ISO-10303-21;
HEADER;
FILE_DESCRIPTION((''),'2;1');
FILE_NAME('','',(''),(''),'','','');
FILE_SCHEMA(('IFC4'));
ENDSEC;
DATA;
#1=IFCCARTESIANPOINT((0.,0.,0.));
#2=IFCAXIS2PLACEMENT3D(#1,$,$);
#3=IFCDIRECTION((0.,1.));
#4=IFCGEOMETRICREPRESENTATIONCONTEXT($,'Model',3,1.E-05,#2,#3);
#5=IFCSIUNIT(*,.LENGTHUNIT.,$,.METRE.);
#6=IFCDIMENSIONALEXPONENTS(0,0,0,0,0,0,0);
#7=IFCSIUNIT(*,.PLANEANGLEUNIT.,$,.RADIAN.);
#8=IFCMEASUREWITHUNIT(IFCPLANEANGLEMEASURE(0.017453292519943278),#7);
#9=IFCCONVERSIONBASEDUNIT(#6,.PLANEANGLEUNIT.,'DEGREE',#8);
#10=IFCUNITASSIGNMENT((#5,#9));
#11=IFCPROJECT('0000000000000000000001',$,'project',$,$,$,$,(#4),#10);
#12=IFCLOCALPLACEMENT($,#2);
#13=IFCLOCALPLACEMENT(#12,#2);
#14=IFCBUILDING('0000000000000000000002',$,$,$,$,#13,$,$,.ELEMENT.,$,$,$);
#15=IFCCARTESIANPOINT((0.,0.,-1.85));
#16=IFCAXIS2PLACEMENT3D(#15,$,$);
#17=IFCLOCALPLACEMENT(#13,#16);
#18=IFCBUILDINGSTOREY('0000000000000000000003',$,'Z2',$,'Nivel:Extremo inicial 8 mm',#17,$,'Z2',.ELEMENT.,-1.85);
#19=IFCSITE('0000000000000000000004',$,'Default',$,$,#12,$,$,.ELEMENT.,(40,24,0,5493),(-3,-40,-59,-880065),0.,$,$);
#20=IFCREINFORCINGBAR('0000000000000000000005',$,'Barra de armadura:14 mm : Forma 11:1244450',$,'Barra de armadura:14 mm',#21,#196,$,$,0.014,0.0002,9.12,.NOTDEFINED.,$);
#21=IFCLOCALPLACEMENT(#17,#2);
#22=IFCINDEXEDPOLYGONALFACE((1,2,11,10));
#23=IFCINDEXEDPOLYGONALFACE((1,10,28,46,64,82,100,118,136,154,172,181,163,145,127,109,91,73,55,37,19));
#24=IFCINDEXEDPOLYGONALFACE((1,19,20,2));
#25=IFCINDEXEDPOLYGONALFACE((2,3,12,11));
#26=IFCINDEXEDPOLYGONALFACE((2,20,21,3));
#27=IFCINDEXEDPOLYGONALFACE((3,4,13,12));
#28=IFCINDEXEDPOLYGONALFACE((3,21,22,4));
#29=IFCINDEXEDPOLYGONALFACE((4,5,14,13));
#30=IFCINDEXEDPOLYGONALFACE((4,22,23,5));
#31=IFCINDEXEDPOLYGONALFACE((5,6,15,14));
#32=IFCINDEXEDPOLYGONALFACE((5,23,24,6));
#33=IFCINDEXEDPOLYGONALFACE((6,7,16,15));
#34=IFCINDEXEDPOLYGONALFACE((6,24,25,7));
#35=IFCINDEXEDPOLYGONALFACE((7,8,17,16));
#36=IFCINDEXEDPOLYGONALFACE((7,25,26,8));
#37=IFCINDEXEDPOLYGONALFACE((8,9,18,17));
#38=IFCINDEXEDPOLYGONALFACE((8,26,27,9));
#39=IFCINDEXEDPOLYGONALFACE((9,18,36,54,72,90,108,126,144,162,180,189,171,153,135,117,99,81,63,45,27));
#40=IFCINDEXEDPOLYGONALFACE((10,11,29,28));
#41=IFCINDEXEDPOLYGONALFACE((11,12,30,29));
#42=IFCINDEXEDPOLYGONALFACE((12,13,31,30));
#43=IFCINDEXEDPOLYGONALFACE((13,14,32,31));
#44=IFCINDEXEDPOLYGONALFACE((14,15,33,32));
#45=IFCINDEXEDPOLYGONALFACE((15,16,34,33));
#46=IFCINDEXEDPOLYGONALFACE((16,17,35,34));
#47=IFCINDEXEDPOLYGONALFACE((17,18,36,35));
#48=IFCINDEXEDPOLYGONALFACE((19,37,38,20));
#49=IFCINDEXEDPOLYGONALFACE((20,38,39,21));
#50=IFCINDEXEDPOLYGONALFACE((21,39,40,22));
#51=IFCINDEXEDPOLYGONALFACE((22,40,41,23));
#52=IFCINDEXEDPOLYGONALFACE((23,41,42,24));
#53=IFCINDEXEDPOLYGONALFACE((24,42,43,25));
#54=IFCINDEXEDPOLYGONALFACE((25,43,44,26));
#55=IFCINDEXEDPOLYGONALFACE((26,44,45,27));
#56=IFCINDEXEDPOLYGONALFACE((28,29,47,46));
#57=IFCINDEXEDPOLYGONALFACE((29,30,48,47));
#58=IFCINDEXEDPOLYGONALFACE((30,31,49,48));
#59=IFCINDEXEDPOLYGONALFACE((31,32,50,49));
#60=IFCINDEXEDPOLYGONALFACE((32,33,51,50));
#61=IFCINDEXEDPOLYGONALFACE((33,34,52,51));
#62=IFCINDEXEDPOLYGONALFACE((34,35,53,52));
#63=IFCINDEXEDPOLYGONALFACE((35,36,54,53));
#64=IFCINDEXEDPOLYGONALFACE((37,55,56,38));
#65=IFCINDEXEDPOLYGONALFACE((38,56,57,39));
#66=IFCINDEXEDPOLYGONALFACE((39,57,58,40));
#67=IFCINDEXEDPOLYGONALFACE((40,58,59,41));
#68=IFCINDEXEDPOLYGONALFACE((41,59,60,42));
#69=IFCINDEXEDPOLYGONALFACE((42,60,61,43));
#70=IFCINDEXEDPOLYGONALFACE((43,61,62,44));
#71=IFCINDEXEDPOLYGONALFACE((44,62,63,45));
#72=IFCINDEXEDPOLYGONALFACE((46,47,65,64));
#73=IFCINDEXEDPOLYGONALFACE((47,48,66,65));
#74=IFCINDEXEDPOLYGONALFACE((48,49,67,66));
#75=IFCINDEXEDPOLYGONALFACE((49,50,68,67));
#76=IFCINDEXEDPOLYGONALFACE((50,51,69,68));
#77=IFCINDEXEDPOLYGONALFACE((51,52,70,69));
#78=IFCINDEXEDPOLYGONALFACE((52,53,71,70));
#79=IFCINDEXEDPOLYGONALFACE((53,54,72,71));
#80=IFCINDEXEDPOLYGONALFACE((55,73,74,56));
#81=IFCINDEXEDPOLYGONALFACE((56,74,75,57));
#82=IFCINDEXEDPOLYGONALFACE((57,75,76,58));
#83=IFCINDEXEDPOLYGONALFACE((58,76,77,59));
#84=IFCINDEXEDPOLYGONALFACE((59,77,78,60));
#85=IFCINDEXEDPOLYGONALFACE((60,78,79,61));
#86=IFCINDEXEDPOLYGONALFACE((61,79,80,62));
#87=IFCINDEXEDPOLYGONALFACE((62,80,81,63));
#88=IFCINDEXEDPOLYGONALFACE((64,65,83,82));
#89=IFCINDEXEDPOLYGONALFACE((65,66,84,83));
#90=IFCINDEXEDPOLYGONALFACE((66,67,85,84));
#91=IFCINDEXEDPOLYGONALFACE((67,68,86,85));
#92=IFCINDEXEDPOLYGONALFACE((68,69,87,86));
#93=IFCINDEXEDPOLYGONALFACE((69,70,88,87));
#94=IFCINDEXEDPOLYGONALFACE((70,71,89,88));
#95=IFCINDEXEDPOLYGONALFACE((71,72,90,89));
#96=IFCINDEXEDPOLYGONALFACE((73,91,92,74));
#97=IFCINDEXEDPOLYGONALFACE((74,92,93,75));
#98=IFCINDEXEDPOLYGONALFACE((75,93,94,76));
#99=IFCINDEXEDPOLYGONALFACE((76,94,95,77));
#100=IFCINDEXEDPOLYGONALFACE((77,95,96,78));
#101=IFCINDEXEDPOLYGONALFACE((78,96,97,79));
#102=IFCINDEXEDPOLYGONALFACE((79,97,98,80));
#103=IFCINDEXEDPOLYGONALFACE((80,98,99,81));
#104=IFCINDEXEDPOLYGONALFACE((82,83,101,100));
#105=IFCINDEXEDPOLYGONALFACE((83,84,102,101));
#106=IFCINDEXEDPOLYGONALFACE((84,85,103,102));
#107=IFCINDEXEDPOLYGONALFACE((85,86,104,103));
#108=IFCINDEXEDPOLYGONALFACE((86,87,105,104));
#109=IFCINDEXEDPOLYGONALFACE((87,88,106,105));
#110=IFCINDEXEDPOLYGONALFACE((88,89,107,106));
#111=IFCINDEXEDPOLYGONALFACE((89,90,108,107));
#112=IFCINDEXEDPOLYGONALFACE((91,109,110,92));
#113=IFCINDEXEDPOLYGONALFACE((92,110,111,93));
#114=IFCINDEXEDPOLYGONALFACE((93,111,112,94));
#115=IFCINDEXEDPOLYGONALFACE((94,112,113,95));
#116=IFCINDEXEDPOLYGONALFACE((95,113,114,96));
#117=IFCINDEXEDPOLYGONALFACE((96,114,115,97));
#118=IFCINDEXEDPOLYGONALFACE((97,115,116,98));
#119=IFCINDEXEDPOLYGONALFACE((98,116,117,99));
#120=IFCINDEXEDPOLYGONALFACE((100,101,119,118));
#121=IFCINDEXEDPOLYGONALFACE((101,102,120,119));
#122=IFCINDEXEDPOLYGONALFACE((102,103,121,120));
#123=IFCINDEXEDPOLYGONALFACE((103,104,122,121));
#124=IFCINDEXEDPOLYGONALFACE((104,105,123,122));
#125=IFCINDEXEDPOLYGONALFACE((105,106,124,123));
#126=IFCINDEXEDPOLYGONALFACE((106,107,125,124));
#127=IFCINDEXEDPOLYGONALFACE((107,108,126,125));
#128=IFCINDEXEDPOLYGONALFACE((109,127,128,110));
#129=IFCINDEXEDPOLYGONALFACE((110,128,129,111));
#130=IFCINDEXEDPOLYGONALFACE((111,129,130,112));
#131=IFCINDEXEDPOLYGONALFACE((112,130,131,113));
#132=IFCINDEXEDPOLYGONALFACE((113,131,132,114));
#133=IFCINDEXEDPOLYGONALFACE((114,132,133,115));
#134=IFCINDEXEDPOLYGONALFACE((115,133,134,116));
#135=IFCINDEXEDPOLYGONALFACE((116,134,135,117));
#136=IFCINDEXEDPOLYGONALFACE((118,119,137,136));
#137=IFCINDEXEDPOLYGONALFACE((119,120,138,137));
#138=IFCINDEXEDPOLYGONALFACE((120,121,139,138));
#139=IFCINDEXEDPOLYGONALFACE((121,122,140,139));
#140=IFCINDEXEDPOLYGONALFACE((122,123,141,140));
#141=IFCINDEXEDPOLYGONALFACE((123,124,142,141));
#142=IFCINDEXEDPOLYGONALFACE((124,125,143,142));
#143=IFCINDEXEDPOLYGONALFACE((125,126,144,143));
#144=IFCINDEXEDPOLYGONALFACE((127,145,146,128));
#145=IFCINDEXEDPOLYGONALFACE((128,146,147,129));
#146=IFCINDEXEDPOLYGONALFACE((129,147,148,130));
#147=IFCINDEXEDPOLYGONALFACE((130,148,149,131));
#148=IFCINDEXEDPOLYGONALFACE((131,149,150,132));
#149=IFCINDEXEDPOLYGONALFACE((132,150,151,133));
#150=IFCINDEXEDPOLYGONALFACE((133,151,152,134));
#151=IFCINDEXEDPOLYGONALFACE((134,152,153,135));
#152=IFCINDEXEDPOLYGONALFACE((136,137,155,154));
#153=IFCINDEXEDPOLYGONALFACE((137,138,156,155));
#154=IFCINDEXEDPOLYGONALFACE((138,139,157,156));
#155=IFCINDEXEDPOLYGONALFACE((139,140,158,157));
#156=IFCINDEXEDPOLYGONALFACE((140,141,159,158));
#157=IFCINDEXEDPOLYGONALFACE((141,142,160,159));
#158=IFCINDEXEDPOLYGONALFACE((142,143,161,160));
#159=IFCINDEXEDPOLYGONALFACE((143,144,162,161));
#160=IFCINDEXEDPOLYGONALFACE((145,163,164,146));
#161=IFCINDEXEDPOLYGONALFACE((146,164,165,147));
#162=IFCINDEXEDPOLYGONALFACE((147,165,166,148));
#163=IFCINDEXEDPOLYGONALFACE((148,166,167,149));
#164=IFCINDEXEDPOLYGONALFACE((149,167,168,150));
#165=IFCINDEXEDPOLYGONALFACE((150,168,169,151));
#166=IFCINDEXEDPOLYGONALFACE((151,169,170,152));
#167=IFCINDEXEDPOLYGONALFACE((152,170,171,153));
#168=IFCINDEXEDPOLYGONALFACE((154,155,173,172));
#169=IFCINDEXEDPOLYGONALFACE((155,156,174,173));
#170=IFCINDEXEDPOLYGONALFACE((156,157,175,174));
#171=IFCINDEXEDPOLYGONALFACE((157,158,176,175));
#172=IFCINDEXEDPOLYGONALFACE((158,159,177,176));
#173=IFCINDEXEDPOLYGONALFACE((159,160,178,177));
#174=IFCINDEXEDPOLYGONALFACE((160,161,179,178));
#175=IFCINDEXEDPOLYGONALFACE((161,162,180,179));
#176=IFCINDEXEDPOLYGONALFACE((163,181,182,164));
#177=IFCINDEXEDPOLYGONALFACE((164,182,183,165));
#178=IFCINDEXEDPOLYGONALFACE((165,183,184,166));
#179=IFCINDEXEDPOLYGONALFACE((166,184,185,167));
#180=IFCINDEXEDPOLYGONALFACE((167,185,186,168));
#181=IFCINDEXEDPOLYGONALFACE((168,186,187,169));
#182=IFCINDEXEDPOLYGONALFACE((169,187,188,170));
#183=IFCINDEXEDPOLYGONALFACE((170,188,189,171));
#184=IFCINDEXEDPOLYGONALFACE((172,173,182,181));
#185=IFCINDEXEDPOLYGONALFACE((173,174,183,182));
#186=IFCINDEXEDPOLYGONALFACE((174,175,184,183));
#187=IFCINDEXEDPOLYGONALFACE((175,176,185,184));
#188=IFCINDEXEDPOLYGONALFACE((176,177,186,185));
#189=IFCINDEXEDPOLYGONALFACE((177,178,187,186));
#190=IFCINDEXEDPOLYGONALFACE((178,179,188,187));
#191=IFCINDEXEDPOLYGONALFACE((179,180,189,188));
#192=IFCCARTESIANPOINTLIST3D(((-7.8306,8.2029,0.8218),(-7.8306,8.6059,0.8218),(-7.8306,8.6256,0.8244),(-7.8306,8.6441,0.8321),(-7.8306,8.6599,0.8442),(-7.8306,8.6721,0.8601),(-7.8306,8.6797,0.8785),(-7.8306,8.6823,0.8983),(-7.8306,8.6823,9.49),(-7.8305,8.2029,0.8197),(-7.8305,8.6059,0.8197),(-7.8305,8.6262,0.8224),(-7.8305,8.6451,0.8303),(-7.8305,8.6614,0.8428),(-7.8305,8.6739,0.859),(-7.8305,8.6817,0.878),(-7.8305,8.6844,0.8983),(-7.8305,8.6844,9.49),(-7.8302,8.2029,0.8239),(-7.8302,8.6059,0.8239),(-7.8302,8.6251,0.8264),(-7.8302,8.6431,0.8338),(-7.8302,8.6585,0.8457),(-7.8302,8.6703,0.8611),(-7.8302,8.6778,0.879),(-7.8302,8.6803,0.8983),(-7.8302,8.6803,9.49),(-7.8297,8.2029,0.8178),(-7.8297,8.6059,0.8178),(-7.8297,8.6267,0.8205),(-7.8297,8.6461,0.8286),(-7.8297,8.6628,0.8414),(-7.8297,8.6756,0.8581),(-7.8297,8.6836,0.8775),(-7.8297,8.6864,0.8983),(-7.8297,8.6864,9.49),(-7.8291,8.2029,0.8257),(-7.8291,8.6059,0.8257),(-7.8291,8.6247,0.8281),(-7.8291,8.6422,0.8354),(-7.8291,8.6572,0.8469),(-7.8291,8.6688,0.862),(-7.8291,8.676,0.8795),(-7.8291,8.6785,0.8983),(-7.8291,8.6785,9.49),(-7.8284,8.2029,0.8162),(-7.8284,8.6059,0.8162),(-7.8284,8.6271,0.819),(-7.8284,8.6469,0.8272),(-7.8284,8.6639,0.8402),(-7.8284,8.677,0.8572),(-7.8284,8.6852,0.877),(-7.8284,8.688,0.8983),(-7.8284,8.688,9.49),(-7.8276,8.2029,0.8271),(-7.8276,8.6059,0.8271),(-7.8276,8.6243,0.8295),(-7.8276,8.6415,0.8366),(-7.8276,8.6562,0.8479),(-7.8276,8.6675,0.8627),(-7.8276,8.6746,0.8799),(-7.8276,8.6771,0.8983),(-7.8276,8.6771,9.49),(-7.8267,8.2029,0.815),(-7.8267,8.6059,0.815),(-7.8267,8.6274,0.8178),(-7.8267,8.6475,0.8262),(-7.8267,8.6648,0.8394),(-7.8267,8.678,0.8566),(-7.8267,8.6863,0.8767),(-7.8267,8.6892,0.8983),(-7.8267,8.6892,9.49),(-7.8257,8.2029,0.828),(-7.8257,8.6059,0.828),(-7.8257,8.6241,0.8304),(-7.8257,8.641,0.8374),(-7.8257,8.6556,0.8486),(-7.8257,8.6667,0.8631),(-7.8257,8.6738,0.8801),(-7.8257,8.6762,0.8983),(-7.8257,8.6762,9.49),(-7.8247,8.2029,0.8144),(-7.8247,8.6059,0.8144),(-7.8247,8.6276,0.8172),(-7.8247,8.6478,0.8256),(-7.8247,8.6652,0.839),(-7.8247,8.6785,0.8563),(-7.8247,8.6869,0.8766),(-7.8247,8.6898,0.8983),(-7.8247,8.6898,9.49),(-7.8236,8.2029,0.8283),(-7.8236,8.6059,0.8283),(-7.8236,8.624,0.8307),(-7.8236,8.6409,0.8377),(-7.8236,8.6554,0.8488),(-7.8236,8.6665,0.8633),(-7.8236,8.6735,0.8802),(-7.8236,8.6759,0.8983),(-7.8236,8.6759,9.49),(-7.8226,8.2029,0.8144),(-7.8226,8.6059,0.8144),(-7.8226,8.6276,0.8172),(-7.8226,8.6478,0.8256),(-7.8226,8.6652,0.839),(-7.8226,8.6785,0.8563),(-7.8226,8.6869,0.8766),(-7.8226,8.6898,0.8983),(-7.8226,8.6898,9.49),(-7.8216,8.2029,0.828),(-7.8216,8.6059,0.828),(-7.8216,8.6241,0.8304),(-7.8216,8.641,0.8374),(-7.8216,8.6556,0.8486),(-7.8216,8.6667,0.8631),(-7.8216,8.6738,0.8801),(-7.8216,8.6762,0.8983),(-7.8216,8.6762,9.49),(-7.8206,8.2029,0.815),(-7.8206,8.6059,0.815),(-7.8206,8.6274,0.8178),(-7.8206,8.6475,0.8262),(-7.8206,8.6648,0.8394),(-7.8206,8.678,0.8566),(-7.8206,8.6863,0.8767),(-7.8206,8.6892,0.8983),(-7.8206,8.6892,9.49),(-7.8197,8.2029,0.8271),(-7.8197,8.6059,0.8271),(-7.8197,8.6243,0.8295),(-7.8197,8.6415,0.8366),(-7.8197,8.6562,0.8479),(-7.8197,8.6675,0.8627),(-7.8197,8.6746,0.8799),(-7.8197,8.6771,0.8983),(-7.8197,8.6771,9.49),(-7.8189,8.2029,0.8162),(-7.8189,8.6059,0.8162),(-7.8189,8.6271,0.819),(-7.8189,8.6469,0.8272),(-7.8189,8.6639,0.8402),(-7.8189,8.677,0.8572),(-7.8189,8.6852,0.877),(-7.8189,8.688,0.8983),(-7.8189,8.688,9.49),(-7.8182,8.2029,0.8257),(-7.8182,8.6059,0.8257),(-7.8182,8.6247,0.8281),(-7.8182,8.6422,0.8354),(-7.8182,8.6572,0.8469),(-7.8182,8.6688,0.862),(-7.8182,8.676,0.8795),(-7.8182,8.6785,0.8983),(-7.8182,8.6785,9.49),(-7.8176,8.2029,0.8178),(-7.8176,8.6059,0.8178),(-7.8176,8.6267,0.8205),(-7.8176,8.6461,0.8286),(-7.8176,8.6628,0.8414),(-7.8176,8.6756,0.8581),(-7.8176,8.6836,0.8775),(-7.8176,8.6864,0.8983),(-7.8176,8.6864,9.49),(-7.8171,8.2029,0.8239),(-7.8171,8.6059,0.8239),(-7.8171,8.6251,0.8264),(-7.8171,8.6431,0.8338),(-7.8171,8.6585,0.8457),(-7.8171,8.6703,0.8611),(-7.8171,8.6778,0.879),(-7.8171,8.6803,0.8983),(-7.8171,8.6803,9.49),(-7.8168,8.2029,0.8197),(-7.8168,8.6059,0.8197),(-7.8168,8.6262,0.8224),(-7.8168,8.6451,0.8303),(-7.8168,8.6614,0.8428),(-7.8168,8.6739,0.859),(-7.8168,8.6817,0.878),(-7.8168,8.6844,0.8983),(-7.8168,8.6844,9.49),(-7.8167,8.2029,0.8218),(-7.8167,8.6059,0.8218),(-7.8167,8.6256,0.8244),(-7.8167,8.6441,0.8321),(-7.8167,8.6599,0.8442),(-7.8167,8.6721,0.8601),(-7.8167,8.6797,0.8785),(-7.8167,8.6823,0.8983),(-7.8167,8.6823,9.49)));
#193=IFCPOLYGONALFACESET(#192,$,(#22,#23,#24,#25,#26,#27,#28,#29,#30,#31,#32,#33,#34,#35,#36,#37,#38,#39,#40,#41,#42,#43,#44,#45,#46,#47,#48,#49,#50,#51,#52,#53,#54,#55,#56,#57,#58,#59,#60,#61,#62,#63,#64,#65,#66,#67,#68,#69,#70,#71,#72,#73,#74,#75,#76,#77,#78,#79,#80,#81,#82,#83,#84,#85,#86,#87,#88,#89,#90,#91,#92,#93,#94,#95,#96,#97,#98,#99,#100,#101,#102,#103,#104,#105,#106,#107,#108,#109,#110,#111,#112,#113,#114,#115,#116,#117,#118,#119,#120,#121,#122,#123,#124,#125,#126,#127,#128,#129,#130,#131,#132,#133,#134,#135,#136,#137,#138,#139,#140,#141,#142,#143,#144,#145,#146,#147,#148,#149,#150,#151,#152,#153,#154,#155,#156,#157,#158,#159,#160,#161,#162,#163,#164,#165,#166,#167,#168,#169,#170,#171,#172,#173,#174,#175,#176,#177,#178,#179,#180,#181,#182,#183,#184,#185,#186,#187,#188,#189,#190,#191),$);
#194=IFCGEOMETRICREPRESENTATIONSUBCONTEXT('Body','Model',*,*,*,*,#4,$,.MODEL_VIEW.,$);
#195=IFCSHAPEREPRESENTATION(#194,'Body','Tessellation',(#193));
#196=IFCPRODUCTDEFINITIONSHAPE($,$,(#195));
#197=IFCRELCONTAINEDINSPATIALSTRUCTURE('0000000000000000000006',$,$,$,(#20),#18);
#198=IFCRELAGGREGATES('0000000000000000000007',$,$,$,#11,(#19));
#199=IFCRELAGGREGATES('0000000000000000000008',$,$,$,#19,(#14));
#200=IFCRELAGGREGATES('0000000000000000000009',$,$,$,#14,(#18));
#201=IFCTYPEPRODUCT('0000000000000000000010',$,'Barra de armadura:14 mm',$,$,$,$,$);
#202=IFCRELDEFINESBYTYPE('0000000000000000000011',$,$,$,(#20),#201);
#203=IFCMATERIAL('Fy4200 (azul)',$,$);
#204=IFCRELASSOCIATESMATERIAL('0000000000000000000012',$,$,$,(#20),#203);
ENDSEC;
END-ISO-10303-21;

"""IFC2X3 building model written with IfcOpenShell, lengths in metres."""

from ifc_helpers import new_model, entity, si_unit, converted_unit, direction, frame, origin, place, context, subcontext, project, spatial, material, type_object, element, save


model = new_model("IFC2X3")

# Units and contexts
model_context = context("Model", 3, precision=1e-05, world=origin(), true_north=direction((0.0, 1.0)))
body_context = subcontext(model_context, "Body", "Model", "MODEL_VIEW")
ifc_project = project(units=[si_unit("LENGTHUNIT", "METRE"), converted_unit("PLANEANGLEUNIT", "DEGREE", entity("IfcPlaneAngleMeasure", 0.017453292519943278), si_unit("PLANEANGLEUNIT", "RADIAN"), dimensions=[0, 0, 0, 0, 0, 0, 0])], contexts=[model_context])

# Site, building, storey
site_placement = place(None, origin())
site = spatial("IfcSite", under=ifc_project, at=site_placement, Name="Default", CompositionType="ELEMENT", RefLatitude=(40, 24, 0, 5493), RefLongitude=(-3, -40, -59, -880065), RefElevation=0.0)
building_placement = place(site_placement, origin())
building = spatial("IfcBuilding", under=site, at=building_placement, CompositionType="ELEMENT")
storey_placement = place(building_placement, frame((0.0, 0.0, -1.85)))
storey = spatial("IfcBuildingStorey", under=building, at=storey_placement, Name="Z2", ObjectType="Nivel:Extremo inicial 8 mm", LongName="Z2", CompositionType="ELEMENT", Elevation=-1.85)

# Reinforcing bar
ifc_material_1 = material(Name="Fy4200 (azul)")
type_product_1 = type_object("IfcTypeProduct", Name="Barra de armadura:14 mm")
reinforcing_bar_1_placement = place(storey_placement, origin())
element("IfcReinforcingBar", 1, at=reinforcing_bar_1_placement, inside=storey, type_object=type_product_1, material=ifc_material_1, Name="Barra de armadura:14 mm : Forma 11:1244450", ObjectType="Barra de armadura:14 mm", BarLength=9.12, BarRole="NOTDEFINED", CrossSectionArea=0.0002, NominalDiameter=0.014, context=body_context, shape_type="AdvancedSweptSolid", body=[
    entity("IfcSweptDiskSolid", entity("IfcCompositeCurve", [entity("IfcCompositeCurveSegment", "CONTINUOUS", True, entity("IfcPolyline", [entity("IfcCartesianPoint", [-7.8236, 8.6829, 9.49]), entity("IfcCartesianPoint", [-7.8236, 8.6829, 0.8983])])), entity("IfcCompositeCurveSegment", "CONTINUOUS", True, entity("IfcTrimmedCurve", entity("IfcCircle", entity("IfcAxis2Placement3D", entity("IfcCartesianPoint", [-7.8236, 8.6059, 0.8983]), entity("IfcDirection", [-1.0, 0.0, 0.0]), entity("IfcDirection", [0.0, 0.0, -1.0])), 0.077), [entity("IfcParameterValue", 270.0)], [entity("IfcParameterValue", 360.0)], True, "PARAMETER")), entity("IfcCompositeCurveSegment", "CONTINUOUS", True, entity("IfcPolyline", [entity("IfcCartesianPoint", [-7.8236, 8.6059, 0.8213]), entity("IfcCartesianPoint", [-7.8236, 8.2029, 0.8213])]))], False), 0.007, None, 0.0, 92.0),
])

save(model, "model.ifc")
